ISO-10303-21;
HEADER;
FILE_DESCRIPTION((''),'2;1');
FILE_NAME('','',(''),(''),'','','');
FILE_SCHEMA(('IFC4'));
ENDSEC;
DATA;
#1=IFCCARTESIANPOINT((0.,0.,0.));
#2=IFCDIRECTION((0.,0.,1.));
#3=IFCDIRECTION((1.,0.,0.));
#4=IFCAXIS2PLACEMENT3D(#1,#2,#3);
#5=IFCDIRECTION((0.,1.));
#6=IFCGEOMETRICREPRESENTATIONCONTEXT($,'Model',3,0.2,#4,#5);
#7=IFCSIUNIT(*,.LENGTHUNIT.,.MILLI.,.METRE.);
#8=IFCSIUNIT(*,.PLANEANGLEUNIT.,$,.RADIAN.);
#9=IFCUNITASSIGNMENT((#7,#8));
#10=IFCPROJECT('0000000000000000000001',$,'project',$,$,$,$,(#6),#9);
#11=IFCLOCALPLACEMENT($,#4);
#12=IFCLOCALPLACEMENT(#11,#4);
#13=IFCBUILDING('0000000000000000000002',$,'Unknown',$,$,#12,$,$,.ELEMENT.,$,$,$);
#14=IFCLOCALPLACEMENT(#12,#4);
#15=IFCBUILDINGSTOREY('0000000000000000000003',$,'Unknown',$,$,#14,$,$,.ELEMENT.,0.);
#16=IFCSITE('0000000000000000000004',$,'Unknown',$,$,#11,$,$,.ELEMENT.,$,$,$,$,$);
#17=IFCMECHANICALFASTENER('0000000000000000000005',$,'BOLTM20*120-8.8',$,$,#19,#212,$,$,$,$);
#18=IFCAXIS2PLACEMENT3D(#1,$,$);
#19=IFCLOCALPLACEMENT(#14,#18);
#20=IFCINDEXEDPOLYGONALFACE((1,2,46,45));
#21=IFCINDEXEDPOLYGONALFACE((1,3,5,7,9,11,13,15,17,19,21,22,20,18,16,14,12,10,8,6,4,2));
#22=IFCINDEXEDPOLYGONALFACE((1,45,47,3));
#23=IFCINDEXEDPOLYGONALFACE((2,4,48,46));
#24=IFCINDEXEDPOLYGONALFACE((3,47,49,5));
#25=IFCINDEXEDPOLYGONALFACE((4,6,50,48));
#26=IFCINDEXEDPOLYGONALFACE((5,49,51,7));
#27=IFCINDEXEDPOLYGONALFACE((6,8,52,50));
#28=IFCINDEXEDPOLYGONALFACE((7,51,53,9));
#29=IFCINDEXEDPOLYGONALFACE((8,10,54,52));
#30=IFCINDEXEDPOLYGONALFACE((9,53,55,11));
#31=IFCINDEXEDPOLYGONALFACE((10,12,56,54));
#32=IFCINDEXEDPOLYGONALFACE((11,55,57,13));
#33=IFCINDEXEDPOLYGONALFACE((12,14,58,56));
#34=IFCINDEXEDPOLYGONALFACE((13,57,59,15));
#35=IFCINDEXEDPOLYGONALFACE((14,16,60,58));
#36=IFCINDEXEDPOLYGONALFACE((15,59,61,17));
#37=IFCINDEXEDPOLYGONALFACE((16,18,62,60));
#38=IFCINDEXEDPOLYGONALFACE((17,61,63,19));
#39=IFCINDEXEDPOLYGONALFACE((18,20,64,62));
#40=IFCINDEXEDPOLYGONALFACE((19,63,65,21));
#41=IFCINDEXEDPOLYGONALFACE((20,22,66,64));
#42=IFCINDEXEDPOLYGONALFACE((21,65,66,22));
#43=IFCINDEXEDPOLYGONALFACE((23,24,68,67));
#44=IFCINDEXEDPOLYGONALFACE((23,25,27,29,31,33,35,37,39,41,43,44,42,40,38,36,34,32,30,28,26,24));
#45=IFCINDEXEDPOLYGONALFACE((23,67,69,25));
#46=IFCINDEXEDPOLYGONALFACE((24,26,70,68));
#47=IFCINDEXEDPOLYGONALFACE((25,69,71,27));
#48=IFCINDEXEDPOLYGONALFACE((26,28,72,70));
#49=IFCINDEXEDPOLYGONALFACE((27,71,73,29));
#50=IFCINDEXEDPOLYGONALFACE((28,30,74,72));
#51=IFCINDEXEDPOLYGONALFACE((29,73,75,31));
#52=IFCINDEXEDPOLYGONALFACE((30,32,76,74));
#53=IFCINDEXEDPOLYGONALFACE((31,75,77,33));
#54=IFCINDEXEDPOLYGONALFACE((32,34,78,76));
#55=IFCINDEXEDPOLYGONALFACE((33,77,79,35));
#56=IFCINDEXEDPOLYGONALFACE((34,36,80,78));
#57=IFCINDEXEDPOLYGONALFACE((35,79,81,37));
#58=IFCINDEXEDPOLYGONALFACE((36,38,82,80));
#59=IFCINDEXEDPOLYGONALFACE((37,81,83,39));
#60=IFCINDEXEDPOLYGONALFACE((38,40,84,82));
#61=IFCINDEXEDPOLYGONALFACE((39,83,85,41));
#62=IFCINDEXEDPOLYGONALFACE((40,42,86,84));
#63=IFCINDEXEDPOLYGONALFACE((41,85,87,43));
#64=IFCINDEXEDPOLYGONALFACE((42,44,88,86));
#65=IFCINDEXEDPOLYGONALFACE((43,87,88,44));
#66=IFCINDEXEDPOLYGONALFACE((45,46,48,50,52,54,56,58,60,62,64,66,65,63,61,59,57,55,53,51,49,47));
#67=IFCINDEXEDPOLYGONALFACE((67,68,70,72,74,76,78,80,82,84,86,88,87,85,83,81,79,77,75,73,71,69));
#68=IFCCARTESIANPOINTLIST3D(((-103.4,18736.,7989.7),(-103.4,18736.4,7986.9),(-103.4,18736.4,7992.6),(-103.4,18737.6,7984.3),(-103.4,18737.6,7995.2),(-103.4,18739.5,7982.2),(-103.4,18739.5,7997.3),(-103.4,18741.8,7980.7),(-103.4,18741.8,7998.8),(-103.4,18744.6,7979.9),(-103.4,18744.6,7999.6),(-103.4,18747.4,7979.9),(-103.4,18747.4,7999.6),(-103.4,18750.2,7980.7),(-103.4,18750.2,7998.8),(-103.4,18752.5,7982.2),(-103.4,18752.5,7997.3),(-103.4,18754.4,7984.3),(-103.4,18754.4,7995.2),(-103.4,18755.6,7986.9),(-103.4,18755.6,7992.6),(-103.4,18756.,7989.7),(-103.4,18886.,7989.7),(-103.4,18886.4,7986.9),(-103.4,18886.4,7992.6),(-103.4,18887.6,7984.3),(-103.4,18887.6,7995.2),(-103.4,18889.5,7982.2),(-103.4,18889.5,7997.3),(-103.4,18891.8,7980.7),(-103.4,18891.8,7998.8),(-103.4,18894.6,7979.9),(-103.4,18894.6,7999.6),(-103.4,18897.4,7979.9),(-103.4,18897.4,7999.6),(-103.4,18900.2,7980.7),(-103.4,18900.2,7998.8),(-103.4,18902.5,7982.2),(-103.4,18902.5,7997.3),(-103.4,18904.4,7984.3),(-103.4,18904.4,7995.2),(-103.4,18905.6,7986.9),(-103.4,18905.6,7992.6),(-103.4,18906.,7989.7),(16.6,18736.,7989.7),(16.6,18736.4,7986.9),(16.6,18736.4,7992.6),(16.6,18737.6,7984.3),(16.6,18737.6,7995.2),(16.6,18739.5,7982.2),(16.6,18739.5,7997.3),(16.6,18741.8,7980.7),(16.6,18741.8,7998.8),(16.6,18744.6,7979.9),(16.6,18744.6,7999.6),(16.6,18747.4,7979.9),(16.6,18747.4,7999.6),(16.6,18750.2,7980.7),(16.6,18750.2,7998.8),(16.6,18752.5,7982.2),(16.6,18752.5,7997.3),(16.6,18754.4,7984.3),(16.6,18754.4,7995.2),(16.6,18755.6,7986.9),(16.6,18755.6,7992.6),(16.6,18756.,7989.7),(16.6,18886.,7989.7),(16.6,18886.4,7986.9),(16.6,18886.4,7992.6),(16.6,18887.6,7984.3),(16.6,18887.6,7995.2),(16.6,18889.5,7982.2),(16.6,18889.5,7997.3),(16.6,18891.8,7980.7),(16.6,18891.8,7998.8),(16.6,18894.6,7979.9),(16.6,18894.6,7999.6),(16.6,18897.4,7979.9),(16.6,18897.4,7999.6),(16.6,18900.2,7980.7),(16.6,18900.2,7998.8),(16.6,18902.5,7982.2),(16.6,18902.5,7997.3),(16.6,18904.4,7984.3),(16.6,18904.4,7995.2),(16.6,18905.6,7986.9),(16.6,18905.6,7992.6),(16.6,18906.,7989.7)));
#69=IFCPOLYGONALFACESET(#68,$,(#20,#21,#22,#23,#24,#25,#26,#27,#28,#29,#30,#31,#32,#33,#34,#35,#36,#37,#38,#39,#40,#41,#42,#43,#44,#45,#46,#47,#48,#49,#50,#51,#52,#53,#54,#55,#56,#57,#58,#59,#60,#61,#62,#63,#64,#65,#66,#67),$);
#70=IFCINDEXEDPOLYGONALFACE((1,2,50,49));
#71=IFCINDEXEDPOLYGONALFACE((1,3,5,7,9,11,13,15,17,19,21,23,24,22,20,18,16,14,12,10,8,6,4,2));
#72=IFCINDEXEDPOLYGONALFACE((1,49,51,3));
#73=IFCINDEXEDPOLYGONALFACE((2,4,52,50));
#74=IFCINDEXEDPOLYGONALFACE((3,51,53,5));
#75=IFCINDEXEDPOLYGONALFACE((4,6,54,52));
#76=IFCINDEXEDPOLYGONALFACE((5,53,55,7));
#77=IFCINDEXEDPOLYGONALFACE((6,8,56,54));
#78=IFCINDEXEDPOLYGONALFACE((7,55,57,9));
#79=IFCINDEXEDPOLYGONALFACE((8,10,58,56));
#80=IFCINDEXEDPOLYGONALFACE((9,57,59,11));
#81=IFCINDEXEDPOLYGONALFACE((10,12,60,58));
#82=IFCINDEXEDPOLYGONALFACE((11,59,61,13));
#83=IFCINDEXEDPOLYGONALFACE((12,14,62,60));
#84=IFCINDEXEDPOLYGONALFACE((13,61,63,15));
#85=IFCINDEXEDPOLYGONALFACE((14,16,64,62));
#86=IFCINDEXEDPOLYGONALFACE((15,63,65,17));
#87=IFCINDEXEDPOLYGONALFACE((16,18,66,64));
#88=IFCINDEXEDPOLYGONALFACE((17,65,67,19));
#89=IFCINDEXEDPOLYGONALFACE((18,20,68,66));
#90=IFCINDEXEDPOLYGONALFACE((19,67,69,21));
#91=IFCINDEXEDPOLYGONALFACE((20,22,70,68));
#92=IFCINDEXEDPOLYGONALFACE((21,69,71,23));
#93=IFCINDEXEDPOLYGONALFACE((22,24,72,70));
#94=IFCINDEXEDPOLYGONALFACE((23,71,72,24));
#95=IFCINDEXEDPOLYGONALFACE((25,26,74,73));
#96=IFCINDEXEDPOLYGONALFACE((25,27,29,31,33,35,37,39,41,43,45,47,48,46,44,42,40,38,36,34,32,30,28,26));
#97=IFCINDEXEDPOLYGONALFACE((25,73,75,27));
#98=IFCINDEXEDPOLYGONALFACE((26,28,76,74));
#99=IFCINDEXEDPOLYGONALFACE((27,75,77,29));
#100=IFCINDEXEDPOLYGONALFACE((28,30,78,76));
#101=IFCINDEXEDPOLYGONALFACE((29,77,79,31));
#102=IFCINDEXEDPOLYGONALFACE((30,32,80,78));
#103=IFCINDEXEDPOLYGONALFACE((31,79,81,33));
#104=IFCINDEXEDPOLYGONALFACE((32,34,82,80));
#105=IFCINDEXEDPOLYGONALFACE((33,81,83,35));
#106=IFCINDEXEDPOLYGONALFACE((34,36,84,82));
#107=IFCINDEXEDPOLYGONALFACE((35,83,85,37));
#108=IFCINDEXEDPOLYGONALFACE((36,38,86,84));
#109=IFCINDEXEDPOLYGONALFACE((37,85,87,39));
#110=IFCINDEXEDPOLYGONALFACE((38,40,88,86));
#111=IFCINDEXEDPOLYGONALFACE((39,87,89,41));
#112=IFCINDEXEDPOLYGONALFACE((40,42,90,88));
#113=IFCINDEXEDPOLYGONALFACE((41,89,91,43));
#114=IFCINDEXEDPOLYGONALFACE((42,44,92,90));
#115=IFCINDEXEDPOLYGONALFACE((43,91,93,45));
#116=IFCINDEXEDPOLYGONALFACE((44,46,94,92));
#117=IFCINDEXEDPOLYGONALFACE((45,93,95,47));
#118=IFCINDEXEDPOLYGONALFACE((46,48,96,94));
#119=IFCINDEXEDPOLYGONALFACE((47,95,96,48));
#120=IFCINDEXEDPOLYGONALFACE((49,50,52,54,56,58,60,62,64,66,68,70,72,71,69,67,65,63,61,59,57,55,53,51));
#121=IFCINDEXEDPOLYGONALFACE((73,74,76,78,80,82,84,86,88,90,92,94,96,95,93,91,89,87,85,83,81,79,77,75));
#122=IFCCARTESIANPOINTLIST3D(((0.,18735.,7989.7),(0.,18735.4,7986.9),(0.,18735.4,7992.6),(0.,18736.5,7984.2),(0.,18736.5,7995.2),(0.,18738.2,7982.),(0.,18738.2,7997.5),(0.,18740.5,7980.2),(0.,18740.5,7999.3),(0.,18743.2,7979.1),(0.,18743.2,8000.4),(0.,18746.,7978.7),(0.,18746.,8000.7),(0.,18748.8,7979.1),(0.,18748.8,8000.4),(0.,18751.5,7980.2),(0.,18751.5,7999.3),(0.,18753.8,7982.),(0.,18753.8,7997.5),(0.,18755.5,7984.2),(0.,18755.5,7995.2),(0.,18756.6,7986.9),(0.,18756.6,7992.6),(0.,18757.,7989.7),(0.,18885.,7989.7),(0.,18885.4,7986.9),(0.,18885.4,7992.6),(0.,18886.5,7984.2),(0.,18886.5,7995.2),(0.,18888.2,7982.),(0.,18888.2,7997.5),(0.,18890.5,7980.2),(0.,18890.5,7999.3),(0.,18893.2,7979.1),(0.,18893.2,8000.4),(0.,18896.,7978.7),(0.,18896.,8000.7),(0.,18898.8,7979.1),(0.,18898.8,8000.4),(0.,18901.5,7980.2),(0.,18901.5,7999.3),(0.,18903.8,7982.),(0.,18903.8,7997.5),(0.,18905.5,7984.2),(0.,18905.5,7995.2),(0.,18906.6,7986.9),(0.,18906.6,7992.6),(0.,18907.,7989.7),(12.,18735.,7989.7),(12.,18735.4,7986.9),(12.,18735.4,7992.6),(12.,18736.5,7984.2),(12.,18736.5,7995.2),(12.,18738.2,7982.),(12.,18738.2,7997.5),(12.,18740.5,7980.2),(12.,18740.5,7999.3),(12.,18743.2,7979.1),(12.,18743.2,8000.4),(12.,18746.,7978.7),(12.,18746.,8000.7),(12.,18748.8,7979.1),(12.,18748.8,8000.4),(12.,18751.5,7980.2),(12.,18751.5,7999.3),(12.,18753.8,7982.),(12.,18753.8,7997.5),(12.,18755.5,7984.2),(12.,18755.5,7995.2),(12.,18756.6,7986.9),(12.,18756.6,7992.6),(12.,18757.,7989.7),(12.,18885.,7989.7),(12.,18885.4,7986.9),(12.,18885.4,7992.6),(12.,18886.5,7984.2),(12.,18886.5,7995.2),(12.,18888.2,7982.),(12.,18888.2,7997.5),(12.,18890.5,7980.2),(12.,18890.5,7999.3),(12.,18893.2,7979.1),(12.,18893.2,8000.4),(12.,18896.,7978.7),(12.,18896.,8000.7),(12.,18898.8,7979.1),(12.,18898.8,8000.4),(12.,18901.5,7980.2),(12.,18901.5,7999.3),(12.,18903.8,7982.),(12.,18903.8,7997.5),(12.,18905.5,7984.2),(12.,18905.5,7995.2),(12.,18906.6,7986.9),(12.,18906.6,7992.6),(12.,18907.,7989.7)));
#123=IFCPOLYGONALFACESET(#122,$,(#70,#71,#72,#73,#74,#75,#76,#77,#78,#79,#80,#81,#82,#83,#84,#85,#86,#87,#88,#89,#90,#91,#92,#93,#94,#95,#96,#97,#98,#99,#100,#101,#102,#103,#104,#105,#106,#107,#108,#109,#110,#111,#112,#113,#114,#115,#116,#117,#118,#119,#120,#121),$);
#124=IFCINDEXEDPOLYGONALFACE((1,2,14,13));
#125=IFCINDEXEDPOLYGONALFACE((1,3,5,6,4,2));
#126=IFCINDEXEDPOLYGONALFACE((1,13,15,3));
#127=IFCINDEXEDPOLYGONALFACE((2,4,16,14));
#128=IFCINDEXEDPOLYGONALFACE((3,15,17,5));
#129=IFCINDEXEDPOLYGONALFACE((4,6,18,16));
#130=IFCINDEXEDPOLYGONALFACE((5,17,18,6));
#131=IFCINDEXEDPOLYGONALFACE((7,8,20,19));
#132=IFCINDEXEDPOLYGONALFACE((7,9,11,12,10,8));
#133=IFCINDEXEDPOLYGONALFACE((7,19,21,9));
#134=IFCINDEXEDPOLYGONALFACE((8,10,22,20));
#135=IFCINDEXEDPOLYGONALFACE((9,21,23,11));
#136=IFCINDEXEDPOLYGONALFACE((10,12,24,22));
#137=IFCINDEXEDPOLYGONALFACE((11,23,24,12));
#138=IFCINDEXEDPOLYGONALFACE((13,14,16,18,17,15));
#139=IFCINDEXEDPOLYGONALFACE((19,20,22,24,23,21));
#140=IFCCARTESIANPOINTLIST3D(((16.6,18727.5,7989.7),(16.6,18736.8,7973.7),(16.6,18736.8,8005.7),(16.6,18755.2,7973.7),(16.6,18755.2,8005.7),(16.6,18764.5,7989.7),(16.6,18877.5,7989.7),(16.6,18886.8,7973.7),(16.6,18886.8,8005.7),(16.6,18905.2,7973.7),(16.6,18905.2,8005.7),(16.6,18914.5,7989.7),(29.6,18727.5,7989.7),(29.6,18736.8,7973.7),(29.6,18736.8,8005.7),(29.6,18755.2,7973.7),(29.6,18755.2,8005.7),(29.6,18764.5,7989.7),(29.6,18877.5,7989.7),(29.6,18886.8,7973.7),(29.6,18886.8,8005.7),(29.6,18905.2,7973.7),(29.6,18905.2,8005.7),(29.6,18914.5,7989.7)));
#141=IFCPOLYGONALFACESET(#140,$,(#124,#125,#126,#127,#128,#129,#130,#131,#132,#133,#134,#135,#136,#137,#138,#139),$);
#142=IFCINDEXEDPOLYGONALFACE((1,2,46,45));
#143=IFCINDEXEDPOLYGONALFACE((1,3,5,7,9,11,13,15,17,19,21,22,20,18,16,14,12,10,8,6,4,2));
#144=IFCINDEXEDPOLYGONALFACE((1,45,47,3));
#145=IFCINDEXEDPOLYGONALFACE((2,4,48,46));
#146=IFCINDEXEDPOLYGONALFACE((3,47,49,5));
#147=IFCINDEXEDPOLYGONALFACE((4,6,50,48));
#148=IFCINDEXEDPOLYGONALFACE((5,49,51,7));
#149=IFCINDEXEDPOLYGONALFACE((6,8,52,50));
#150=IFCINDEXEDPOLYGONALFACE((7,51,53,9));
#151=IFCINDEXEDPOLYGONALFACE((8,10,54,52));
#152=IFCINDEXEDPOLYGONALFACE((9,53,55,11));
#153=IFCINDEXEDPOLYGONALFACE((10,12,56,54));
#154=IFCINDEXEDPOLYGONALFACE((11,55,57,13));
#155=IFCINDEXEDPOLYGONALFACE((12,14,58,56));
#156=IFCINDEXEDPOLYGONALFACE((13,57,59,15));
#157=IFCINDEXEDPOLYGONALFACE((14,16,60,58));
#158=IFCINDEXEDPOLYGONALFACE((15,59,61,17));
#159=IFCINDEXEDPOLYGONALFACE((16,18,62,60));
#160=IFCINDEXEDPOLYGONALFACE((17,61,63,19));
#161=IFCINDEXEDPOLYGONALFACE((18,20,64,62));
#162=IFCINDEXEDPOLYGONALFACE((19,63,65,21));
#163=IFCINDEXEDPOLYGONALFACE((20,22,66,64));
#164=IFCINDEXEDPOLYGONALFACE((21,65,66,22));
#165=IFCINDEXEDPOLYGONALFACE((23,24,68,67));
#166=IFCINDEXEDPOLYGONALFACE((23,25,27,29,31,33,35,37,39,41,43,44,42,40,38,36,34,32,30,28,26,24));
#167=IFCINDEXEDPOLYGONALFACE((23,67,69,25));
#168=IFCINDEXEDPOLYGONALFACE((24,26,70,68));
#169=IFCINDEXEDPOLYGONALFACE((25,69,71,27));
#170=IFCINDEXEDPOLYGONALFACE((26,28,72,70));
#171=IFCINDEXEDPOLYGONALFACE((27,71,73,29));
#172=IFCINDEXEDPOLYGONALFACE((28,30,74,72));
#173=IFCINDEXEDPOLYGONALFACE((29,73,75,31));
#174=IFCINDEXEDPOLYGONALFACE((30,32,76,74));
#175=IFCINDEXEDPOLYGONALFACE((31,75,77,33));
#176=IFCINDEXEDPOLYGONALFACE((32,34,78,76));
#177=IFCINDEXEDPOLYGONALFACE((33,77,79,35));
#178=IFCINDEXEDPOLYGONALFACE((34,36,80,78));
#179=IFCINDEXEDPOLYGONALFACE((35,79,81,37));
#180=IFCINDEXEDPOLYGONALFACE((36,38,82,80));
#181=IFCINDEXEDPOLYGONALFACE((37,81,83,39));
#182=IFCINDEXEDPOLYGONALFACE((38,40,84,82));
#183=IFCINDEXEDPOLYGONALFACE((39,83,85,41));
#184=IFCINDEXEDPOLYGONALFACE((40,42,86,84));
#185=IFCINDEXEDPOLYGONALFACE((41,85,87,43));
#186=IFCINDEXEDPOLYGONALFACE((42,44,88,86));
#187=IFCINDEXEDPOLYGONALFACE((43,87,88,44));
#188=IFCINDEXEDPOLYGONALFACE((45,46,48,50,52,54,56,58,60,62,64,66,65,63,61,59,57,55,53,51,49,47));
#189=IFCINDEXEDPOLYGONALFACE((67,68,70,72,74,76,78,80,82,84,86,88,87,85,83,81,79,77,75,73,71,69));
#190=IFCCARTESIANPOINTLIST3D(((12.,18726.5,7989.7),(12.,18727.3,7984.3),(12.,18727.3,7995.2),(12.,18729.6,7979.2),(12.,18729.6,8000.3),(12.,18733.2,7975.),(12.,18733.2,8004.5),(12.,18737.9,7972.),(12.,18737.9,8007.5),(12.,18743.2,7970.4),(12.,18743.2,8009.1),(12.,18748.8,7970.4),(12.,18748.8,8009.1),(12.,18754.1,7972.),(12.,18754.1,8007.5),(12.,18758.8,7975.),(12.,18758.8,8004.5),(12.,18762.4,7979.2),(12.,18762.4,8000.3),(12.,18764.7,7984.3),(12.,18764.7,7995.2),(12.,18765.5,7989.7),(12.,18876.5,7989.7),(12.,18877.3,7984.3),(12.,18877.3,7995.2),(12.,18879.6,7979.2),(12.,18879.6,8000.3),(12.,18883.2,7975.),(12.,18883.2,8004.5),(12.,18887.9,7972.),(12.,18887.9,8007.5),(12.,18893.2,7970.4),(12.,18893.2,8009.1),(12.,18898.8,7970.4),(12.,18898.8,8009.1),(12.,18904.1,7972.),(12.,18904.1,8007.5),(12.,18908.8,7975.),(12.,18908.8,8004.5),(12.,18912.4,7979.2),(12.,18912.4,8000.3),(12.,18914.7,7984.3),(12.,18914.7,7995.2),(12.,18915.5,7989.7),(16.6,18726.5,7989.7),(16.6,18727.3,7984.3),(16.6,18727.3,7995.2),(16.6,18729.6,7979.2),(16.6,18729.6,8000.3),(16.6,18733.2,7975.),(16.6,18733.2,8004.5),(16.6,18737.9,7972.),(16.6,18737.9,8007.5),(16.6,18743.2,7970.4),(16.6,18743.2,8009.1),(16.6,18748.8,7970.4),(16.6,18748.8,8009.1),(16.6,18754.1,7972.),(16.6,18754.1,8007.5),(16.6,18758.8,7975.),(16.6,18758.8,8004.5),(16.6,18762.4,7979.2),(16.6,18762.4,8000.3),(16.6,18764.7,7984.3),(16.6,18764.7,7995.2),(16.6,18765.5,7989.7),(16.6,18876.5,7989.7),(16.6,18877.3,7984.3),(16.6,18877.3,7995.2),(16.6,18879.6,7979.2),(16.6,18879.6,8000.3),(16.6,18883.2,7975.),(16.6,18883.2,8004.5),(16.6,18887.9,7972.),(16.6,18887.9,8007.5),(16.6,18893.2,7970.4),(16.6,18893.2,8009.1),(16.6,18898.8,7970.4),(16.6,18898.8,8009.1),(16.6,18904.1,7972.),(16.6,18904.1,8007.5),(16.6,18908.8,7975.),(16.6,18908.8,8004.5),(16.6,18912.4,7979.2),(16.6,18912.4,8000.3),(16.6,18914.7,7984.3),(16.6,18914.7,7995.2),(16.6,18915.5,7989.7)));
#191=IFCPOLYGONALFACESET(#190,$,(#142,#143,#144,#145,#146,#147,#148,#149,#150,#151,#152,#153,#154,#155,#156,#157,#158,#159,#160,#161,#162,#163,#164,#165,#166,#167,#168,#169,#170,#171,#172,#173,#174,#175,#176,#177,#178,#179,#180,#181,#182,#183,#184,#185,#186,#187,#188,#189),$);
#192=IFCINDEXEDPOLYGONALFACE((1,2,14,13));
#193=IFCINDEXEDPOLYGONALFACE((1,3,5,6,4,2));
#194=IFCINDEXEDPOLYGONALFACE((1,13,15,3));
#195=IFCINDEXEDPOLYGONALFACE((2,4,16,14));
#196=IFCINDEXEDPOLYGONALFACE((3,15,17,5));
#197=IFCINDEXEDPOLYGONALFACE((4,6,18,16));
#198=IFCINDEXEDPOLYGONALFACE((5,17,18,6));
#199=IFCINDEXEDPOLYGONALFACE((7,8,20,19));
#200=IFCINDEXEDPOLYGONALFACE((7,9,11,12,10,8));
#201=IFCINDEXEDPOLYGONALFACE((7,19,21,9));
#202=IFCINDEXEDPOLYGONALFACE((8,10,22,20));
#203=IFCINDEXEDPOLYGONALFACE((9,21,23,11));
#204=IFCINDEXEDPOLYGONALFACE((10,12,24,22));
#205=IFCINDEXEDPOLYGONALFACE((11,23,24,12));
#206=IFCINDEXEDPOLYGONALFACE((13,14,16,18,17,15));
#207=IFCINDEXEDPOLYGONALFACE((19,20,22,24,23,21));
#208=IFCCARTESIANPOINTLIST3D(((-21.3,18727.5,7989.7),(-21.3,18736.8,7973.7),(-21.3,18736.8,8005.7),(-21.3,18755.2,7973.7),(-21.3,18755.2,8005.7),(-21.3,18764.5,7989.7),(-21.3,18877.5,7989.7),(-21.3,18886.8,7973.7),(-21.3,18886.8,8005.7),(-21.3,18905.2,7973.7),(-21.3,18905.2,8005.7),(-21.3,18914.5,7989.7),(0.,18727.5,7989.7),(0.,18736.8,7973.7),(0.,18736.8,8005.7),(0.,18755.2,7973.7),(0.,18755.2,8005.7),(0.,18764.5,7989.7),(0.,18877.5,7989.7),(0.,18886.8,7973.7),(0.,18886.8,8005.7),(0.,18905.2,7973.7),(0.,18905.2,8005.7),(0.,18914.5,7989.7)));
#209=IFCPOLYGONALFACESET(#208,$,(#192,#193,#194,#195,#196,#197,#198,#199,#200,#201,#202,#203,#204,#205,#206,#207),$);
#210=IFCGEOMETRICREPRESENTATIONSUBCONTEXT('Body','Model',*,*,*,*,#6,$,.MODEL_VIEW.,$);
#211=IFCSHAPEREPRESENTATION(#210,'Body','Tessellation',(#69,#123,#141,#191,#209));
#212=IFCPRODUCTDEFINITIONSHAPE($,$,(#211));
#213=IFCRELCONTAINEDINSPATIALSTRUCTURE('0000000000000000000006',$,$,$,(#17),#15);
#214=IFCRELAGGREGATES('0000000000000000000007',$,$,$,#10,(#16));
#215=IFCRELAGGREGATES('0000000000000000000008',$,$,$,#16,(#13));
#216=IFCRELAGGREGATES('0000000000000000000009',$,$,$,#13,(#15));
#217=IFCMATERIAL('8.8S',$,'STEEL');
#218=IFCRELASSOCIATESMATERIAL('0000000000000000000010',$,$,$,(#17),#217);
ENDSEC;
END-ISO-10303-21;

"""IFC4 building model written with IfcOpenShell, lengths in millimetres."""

from ifc_helpers import new_model, si_unit, direction, frame, origin_with_axes, place, context, subcontext, project, spatial, line, arc, indexed_curve, outline, extrude, source, transform, mapped, material, element, save


model = new_model("IFC4")

# Units and contexts
model_context = context("Model", 3, precision=0.2, world=origin_with_axes(), true_north=direction((0.0, 1.0)))
body_context = subcontext(model_context, "Body", "Model", "MODEL_VIEW")
ifc_project = project(units=[si_unit("LENGTHUNIT", "METRE", prefix="MILLI"), si_unit("PLANEANGLEUNIT", "RADIAN")], contexts=[model_context])

# Site, building, storey
site_placement = place(None, origin_with_axes())
site = spatial("IfcSite", under=ifc_project, at=site_placement, Name="Unknown", CompositionType="ELEMENT")
building_placement = place(site_placement, origin_with_axes())
building = spatial("IfcBuilding", under=site, at=building_placement, Name="Unknown", CompositionType="ELEMENT")
storey_placement = place(building_placement, origin_with_axes())
storey = spatial("IfcBuildingStorey", under=building, at=storey_placement, Name="Unknown", CompositionType="ELEMENT", Elevation=0.0)

# Mechanical fastener
ifc_material_1 = material(Name="8.8S", Category="STEEL")
shared_shape_1 = source(origin_with_axes(), body_context, "Body", "SweptSolid", [
    extrude(outline(indexed_curve([(10.0, 0.0), (0.0, 10.0), (-10.0, 0.0), (0.0, -10.0)], segments=[arc(1, 2, 3), arc(3, 4, 1)])), frame((0.0, 0.0, 4.6), z_axis=(0.0, 0.0, -1.0), x_axis=(0.0, 1.0, 0.0)), (0.0, 0.0, 1.0), 120.0),
    extrude(outline(indexed_curve([(0.0, 11.0), (7.8, 7.8), (11.0, 0.0), (7.8, -7.8), (0.0, -11.0), (-1.0, -11.0), (-11.0, 0.0), (-7.8, 7.8)], segments=[arc(1, 2, 3), arc(3, 4, 5), arc(5, 6, 7), arc(7, 8, 1)])), frame((0.0, 0.0, 0.0), z_axis=(0.0, 0.0, -1.0), x_axis=(0.0, 1.0, 0.0)), (0.0, 0.0, 1.0), 12.0),
    extrude(outline(indexed_curve([(18.5, 0.0), (9.2, 16.0), (-9.2, 16.0), (-18.5, 0.0), (-9.2, -16.0), (9.2, -16.0)], segments=[line(1, 2, 3, 4, 5, 6, 1)])), frame((0.0, 0.0, 17.6), z_axis=(0.0, 0.0, -1.0), x_axis=(0.0, 1.0, 0.0)), (0.0, 0.0, 1.0), 13.0),
    extrude(outline(indexed_curve([(19.5, 0.0), (0.0, 19.5), (-19.5, 0.0), (0.0, -19.5)], segments=[arc(1, 2, 3), arc(3, 4, 1)])), frame((0.0, 0.0, 4.6), z_axis=(0.0, 0.0, -1.0), x_axis=(0.0, 1.0, 0.0)), (0.0, 0.0, 1.0), 4.6),
    extrude(outline(indexed_curve([(18.5, 0.0), (9.2, 16.0), (-9.2, 16.0), (-18.5, 0.0), (-9.2, -16.0), (9.2, -16.0)], segments=[line(1, 2, 3, 4, 5, 6, 1)])), frame((0.0, 0.0, -12.0), z_axis=(0.0, 0.0, -1.0), x_axis=(0.0, 1.0, 0.0)), (0.0, 0.0, 1.0), 21.3),
])
mechanical_fastener_1_placement = place(storey_placement, frame((12.0, 18821.0, 7989.7), z_axis=(1.0, 0.0, 0.0), x_axis=(0.0, 0.0, -1.0)))
element("IfcMechanicalFastener", 1, at=mechanical_fastener_1_placement, inside=storey, material=ifc_material_1, Name="BOLTM20*120-8.8", context=body_context, shape_type="MappedRepresentation", body=[
    mapped(shared_shape_1, transform((0.0, -75.0, 0.0))),
    mapped(shared_shape_1, transform((0.0, 75.0, 0.0))),
])

save(model, "model.ifc")
